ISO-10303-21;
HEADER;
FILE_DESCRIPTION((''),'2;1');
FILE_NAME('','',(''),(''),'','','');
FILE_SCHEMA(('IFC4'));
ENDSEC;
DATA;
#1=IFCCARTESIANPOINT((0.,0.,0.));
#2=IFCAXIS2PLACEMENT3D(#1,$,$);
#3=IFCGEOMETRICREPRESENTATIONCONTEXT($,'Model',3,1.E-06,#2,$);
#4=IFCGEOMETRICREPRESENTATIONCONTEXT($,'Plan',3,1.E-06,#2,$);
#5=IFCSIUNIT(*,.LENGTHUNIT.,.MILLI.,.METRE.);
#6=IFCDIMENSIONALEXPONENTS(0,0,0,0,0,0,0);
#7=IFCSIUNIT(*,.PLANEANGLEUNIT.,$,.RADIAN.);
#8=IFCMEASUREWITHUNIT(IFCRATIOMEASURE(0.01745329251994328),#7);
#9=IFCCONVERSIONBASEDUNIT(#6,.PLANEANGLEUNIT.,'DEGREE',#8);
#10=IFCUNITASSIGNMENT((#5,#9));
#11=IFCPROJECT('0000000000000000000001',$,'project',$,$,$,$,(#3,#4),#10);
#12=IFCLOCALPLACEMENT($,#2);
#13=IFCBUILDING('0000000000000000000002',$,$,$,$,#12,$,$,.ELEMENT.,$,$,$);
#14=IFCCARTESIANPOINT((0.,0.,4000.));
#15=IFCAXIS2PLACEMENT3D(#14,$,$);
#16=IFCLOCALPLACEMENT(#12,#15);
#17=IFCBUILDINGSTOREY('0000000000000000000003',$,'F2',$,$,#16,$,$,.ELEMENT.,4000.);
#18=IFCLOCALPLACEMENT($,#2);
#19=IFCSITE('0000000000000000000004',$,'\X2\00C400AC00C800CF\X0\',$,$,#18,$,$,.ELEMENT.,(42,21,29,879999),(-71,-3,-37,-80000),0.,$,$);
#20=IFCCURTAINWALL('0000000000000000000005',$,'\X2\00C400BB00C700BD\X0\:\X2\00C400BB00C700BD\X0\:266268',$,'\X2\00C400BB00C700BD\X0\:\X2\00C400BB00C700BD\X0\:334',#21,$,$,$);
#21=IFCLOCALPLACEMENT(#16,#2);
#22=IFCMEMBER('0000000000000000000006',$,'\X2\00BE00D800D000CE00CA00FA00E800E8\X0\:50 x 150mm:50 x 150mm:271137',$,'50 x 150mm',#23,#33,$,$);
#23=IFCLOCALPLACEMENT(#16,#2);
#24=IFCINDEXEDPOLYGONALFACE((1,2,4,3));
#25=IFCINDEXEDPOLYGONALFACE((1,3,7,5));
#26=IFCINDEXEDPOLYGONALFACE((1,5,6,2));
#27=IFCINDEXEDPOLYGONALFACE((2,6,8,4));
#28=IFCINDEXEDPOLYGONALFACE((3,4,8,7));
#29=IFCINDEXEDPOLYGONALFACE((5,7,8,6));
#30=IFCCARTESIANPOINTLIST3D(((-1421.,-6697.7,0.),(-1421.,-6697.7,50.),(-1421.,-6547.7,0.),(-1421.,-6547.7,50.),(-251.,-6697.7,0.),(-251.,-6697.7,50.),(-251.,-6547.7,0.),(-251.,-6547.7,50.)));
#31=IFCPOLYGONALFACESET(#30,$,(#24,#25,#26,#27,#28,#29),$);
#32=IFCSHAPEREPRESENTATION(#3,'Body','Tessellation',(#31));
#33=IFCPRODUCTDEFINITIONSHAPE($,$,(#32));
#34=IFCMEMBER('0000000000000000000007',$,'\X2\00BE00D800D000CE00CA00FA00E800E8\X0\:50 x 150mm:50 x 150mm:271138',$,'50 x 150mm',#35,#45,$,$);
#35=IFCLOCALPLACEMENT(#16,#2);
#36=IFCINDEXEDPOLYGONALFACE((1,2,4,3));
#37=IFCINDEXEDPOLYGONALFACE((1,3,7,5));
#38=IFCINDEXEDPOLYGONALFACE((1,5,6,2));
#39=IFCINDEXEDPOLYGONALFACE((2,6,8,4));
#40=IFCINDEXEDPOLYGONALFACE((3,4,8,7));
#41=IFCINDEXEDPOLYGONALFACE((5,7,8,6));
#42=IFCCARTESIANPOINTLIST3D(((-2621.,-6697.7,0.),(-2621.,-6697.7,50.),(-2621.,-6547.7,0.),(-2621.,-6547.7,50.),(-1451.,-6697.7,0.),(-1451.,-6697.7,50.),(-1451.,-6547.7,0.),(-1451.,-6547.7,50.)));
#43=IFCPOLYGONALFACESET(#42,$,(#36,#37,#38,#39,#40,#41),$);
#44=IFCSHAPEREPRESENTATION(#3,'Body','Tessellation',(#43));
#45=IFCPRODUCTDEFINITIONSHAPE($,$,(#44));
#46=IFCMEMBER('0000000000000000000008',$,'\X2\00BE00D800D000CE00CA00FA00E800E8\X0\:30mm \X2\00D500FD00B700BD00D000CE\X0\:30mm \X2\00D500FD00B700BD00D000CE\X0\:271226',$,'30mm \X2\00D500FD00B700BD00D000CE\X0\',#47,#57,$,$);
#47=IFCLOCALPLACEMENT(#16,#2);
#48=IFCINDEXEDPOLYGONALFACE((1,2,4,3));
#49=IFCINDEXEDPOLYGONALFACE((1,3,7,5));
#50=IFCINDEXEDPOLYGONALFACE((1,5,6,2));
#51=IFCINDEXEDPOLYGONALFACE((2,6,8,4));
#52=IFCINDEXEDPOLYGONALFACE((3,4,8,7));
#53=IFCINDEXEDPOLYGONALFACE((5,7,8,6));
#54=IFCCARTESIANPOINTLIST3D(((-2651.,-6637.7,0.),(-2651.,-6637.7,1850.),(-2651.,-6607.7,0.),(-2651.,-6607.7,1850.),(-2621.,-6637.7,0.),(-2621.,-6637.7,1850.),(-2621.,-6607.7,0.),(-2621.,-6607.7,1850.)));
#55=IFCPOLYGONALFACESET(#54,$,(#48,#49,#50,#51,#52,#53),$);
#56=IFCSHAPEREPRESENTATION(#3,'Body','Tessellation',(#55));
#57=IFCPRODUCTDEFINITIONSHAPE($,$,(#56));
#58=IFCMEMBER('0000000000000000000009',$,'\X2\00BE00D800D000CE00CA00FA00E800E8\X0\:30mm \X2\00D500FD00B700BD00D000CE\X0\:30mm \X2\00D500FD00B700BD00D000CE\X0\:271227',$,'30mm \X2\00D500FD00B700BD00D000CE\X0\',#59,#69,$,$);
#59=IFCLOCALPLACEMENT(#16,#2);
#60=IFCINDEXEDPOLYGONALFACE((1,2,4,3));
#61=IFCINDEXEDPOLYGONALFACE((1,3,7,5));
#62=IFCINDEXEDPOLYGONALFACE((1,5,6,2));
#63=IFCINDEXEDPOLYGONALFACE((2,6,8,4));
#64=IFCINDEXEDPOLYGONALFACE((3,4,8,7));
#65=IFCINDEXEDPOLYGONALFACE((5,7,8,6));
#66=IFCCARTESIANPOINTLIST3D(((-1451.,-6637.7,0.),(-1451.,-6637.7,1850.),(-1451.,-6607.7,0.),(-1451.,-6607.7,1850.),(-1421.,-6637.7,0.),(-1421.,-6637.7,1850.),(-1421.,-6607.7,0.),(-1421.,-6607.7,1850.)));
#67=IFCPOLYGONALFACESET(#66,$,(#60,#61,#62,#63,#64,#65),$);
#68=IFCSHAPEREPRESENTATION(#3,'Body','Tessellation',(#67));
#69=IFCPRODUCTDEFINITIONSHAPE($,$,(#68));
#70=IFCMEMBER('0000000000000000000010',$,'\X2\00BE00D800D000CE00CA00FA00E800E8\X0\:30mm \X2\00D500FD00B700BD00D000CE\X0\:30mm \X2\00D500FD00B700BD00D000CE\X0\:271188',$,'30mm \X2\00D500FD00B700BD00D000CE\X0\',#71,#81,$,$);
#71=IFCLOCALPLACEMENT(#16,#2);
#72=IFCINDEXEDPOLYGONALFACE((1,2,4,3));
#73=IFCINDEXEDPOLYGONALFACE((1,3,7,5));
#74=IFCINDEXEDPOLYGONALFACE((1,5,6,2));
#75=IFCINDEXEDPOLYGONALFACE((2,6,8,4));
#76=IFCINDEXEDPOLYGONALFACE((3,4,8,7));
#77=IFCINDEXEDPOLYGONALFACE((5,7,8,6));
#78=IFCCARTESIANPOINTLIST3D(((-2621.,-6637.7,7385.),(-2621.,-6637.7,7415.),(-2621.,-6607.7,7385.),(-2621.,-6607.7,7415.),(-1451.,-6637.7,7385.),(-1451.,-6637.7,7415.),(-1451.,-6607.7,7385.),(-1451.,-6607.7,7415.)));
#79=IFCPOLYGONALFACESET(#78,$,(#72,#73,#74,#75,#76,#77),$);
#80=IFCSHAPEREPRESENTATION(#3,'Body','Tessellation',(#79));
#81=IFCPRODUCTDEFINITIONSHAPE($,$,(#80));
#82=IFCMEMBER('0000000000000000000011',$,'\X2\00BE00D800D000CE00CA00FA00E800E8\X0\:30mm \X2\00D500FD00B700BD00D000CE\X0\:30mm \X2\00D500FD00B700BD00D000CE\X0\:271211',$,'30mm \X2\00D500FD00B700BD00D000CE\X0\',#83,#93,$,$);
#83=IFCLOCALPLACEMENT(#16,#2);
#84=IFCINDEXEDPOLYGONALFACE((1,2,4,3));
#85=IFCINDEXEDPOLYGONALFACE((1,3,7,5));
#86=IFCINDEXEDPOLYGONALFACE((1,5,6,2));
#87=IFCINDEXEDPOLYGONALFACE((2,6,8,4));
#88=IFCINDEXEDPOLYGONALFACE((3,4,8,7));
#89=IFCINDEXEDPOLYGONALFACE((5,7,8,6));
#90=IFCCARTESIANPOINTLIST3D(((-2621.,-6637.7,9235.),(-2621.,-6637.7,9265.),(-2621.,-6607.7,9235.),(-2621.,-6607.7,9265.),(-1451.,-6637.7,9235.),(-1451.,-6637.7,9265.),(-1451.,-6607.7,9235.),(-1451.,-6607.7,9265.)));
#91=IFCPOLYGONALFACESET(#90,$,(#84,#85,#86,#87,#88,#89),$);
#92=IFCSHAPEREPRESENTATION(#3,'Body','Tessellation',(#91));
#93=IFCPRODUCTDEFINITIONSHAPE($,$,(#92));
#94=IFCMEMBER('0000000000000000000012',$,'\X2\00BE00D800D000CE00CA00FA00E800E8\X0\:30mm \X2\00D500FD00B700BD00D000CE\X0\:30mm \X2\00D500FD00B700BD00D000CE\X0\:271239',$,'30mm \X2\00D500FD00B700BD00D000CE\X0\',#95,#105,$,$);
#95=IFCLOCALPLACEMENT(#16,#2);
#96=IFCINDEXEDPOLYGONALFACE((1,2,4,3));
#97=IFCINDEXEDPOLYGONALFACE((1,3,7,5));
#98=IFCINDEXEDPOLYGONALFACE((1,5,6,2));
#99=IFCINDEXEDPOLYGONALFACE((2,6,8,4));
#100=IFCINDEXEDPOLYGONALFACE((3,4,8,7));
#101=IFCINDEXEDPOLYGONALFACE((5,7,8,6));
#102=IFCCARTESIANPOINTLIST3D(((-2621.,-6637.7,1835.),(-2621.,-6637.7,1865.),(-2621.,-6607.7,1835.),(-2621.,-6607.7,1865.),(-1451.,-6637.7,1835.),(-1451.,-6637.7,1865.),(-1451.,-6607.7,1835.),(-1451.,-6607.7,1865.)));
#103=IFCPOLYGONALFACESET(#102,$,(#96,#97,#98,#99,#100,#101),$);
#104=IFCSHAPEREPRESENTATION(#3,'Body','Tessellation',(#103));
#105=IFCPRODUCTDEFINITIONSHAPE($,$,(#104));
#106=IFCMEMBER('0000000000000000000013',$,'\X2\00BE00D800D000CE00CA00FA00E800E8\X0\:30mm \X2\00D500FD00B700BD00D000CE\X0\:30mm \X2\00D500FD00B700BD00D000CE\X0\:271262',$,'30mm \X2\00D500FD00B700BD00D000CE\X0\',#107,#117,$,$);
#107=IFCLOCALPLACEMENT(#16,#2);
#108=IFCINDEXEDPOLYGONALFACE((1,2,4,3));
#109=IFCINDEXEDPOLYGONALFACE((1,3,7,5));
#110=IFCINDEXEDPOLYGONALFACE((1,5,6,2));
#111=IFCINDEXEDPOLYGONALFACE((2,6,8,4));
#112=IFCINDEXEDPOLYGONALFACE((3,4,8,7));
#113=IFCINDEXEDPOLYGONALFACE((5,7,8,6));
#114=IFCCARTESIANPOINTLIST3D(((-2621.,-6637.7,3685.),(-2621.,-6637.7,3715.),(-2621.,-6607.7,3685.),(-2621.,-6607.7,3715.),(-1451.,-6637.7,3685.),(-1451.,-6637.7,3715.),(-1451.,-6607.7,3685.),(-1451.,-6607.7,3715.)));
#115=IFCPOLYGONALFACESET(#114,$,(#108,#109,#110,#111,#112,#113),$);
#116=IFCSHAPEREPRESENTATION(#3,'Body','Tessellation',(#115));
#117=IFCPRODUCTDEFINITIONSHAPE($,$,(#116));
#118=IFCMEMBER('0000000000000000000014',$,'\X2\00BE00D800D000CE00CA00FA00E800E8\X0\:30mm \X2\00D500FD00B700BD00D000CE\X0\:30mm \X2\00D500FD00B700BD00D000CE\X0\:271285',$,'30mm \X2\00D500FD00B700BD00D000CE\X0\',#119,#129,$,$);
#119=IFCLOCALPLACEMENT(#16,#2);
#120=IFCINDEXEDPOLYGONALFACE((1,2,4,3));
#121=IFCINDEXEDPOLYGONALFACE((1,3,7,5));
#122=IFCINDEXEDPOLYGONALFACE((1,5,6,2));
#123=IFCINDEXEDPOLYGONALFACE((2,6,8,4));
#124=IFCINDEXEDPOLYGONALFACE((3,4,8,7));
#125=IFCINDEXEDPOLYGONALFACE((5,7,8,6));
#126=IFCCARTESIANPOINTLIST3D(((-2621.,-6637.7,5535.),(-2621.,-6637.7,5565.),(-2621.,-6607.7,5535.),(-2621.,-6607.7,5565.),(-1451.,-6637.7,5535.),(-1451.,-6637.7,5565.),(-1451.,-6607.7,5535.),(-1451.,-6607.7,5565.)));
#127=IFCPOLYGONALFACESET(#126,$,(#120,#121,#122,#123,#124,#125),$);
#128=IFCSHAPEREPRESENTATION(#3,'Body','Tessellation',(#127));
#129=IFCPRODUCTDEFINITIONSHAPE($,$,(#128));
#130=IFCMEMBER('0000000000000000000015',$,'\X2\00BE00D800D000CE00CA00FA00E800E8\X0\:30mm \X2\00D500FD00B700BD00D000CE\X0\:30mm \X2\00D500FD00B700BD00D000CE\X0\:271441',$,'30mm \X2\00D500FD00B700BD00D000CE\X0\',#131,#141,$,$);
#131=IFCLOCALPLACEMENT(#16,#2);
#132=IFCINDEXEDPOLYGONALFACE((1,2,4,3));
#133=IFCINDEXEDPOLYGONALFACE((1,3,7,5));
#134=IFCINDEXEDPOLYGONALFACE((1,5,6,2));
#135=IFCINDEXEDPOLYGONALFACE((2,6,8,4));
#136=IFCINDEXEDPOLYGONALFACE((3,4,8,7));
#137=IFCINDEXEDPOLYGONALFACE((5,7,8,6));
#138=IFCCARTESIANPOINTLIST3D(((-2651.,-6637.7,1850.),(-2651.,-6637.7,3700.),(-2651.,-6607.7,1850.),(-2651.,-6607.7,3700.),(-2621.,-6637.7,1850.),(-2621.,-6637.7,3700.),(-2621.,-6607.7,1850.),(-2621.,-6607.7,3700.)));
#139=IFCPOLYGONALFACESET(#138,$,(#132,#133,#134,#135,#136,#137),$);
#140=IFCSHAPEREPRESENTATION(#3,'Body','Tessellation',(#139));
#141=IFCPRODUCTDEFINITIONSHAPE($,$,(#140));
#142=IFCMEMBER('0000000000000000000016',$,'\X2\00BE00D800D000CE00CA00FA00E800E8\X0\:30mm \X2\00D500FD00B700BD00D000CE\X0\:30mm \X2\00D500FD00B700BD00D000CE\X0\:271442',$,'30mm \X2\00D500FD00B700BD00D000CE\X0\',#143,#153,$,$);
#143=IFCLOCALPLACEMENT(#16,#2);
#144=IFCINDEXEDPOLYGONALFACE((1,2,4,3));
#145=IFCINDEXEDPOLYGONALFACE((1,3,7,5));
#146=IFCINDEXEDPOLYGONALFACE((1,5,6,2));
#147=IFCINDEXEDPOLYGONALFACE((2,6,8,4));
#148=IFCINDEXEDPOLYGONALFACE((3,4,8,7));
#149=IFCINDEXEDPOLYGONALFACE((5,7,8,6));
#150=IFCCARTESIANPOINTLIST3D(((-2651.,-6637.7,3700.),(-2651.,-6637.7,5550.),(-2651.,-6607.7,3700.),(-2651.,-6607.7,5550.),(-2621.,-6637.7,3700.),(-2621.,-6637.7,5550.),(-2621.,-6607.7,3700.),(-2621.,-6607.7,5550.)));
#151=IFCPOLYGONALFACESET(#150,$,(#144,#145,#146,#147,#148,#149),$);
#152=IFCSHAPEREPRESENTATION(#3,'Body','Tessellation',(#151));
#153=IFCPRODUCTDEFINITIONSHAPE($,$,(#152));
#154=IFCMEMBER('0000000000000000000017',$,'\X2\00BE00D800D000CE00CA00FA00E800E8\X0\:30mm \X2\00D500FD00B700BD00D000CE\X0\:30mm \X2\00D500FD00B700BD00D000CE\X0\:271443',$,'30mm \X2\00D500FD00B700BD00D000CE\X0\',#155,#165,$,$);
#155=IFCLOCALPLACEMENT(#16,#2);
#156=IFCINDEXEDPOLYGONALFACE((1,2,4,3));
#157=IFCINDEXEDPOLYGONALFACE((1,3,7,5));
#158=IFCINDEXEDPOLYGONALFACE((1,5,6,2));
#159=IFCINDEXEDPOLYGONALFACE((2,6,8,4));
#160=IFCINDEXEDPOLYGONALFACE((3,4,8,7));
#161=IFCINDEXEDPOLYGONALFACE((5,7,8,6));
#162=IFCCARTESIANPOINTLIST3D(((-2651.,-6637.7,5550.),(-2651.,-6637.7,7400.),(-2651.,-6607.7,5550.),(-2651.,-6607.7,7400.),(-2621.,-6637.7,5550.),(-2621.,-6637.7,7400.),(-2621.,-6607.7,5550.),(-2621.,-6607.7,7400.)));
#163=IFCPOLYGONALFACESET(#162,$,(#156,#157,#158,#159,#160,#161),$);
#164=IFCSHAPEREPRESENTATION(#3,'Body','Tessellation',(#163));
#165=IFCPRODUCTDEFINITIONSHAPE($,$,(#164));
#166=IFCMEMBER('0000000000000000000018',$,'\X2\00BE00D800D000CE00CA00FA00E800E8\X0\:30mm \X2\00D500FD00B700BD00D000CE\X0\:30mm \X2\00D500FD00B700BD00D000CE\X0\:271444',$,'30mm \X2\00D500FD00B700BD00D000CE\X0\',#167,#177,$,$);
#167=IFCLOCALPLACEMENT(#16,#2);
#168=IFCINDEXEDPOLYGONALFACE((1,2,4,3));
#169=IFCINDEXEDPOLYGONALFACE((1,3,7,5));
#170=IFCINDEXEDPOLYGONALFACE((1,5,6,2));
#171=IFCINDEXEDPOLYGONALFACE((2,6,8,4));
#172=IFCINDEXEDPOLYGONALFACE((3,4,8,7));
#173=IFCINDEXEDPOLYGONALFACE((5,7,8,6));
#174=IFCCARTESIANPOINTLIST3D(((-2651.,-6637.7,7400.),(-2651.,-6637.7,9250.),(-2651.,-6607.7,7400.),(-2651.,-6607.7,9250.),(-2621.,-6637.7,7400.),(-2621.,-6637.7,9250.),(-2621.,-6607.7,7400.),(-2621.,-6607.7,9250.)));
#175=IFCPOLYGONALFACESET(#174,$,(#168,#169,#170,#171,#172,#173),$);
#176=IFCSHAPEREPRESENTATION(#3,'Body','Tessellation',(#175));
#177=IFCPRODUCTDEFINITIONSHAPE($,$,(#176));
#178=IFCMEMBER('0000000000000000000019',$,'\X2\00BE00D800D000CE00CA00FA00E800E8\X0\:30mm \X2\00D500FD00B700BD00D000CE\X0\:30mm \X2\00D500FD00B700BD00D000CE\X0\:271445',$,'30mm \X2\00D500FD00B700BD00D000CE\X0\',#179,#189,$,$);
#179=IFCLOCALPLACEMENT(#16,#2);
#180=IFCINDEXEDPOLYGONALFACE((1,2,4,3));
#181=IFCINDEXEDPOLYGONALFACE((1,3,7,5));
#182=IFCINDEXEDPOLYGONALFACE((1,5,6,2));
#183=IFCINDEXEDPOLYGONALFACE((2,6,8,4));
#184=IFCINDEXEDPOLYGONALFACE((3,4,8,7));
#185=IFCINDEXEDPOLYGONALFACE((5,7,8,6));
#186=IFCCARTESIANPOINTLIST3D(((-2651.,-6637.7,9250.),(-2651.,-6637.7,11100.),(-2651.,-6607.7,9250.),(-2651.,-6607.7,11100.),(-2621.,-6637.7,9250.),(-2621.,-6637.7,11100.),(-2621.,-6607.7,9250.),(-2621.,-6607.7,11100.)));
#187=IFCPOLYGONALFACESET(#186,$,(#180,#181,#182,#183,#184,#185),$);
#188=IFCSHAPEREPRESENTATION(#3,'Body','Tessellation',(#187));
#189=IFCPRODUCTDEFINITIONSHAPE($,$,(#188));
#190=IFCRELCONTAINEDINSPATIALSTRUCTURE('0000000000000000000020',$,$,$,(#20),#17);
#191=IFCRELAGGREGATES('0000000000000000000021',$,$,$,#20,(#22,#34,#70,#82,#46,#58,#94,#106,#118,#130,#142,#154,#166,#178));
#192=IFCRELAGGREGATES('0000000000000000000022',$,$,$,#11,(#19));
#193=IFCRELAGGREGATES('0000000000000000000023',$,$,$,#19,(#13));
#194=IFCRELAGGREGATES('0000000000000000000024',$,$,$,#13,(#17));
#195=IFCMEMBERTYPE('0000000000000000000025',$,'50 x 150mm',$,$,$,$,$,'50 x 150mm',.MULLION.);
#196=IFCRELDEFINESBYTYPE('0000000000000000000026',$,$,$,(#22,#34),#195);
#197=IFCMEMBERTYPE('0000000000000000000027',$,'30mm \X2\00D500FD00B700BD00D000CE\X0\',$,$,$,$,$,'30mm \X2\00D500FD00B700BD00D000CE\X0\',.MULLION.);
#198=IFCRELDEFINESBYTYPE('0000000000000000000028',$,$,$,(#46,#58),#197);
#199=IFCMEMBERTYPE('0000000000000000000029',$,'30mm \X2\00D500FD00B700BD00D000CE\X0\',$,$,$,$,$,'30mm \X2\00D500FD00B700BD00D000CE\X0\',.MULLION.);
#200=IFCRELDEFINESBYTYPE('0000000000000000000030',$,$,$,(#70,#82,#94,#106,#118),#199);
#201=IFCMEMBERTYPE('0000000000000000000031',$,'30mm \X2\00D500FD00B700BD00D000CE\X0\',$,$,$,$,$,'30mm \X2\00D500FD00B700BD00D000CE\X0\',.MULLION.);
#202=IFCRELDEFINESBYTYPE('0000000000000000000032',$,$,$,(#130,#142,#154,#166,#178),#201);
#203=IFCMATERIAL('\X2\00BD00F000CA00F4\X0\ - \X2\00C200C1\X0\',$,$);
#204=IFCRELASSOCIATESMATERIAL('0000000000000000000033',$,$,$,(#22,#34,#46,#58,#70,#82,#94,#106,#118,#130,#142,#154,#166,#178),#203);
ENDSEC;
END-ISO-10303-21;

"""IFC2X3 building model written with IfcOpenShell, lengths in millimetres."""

from ifc_helpers import new_model, entity, si_unit, converted_unit, frame, origin, origin_2d_with_axis, place, context, project, spatial, rectangle, extrude, source, transform, mapped, material, type_object, type_shapes, element, aggregate, save


model = new_model("IFC2X3")

# Units and contexts
model_context = context("Model", 3, precision=1e-06, world=origin())
plan_context = context("Plan", 3, precision=1e-06, world=origin())
ifc_project = project(units=[si_unit("LENGTHUNIT", "METRE", prefix="MILLI"), converted_unit("PLANEANGLEUNIT", "DEGREE", entity("IfcRatioMeasure", 0.01745329251994328), si_unit("PLANEANGLEUNIT", "RADIAN"), dimensions=[0, 0, 0, 0, 0, 0, 0])], contexts=[model_context, plan_context])

# Site, building, storey
site_placement = place(None, origin())
site = spatial("IfcSite", under=ifc_project, at=site_placement, Name="Ä¬ÈÏ", CompositionType="ELEMENT", RefLatitude=(42, 21, 29, 879999), RefLongitude=(-71, -3, -37, -80000), RefElevation=0.0)
building_placement = place(None, origin())
building = spatial("IfcBuilding", under=site, at=building_placement, CompositionType="ELEMENT")
storey_placement = place(building_placement, frame((0.0, 0.0, 4000.0)))
storey = spatial("IfcBuildingStorey", under=building, at=storey_placement, Name="F2", CompositionType="ELEMENT", Elevation=4000.0)

# Curtain wall, members
curtain_wall_placement = place(storey_placement, origin())
curtain_wall = element("IfcCurtainWall", 1, at=curtain_wall_placement, inside=storey, Name="Ä»Ç½:Ä»Ç½:266268", ObjectType="Ä»Ç½:Ä»Ç½:334")
ifc_material_1 = material(Name="½ðÊô - ÂÁ")
member_type_1 = type_object("IfcMemberType", Name="50 x 150mm", ElementType="50 x 150mm", PredefinedType="MULLION")
shared_shape_1 = source(origin(), model_context, "Body", "SweptSolid", [
    extrude(rectangle(XDim=50.0, YDim=150.0, at=origin_2d_with_axis()), frame((-25.0, 0.0, -1170.0), z_axis=(0.0, 0.0, 1.0), x_axis=(-1.0, 0.0, 0.0)), (0.0, 0.0, 1.0), 1170.0),
])
type_shapes(member_type_1, [shared_shape_1])
member_1_placement = place(storey_placement, frame((-1421.0, -6622.7, 0.0), z_axis=(-1.0, 0.0, 0.0), x_axis=(0.0, 0.0, -1.0)))
member_1 = element("IfcMember", 2, at=member_1_placement, type_object=member_type_1, material=ifc_material_1, Name="¾ØÐÎÊúèè:50 x 150mm:50 x 150mm:271137", ObjectType="50 x 150mm", context=model_context, shape_type="MappedRepresentation", body=[
    mapped(shared_shape_1, transform((0.0, 0.0, 0.0), scale=1.0)),
])
member_2_placement = place(storey_placement, frame((-2621.0, -6622.7, 0.0), z_axis=(-1.0, 0.0, 0.0), x_axis=(0.0, 0.0, -1.0)))
member_2 = element("IfcMember", 3, at=member_2_placement, type_object=member_type_1, material=ifc_material_1, Name="¾ØÐÎÊúèè:50 x 150mm:50 x 150mm:271138", ObjectType="50 x 150mm", context=model_context, shape_type="MappedRepresentation", body=[
    mapped(shared_shape_1, transform((0.0, 0.0, 0.0), scale=1.0)),
])
member_type_2 = type_object("IfcMemberType", Name="30mm Õý·½ÐÎ", ElementType="30mm Õý·½ÐÎ", PredefinedType="MULLION")
shared_shape_2 = source(origin(), model_context, "Body", "SweptSolid", [
    extrude(rectangle(XDim=30.0, YDim=30.0, at=origin_2d_with_axis()), frame((0.0, 0.0, -1850.0), z_axis=(0.0, 0.0, 1.0), x_axis=(-1.0, 0.0, 0.0)), (0.0, 0.0, 1.0), 1850.0),
])
type_shapes(member_type_2, [shared_shape_2])
member_3_placement = place(storey_placement, frame((-2636.0, -6622.7, 0.0), z_axis=(0.0, 0.0, -1.0), x_axis=(1.0, 0.0, 0.0)))
member_3 = element("IfcMember", 4, at=member_3_placement, type_object=member_type_2, material=ifc_material_1, Name="¾ØÐÎÊúèè:30mm Õý·½ÐÎ:30mm Õý·½ÐÎ:271226", ObjectType="30mm Õý·½ÐÎ", context=model_context, shape_type="MappedRepresentation", body=[
    mapped(shared_shape_2, transform((0.0, 0.0, 0.0), scale=1.0)),
])
member_4_placement = place(storey_placement, frame((-1436.0, -6622.7, 0.0), z_axis=(0.0, 0.0, -1.0), x_axis=(1.0, 0.0, 0.0)))
member_4 = element("IfcMember", 5, at=member_4_placement, type_object=member_type_2, material=ifc_material_1, Name="¾ØÐÎÊúèè:30mm Õý·½ÐÎ:30mm Õý·½ÐÎ:271227", ObjectType="30mm Õý·½ÐÎ", context=model_context, shape_type="MappedRepresentation", body=[
    mapped(shared_shape_2, transform((0.0, 0.0, 0.0), scale=1.0)),
])
member_type_3 = type_object("IfcMemberType", Name="30mm Õý·½ÐÎ", ElementType="30mm Õý·½ÐÎ", PredefinedType="MULLION")
shared_shape_3 = source(origin(), model_context, "Body", "SweptSolid", [
    extrude(rectangle(XDim=30.0, YDim=30.0, at=origin_2d_with_axis()), frame((0.0, 0.0, -1170.0), z_axis=(0.0, 0.0, 1.0), x_axis=(-1.0, 0.0, 0.0)), (0.0, 0.0, 1.0), 1170.0),
])
type_shapes(member_type_3, [shared_shape_3])
placement_1 = place(building_placement, frame((0.0, 0.0, 11400.0)))
member_5_placement = place(placement_1, frame((-1451.0, -6622.7, 0.0), z_axis=(1.0, 0.0, 0.0), x_axis=(0.0, 0.0, 1.0)))
member_5 = element("IfcMember", 6, at=member_5_placement, type_object=member_type_3, material=ifc_material_1, Name="¾ØÐÎÊúèè:30mm Õý·½ÐÎ:30mm Õý·½ÐÎ:271188", ObjectType="30mm Õý·½ÐÎ", context=model_context, shape_type="MappedRepresentation", body=[
    mapped(shared_shape_3, transform((0.0, 0.0, 0.0), scale=1.0)),
])
member_6_placement = place(placement_1, frame((-1451.0, -6622.7, 1850.0), z_axis=(1.0, 0.0, 0.0), x_axis=(0.0, 0.0, 1.0)))
member_6 = element("IfcMember", 7, at=member_6_placement, type_object=member_type_3, material=ifc_material_1, Name="¾ØÐÎÊúèè:30mm Õý·½ÐÎ:30mm Õý·½ÐÎ:271211", ObjectType="30mm Õý·½ÐÎ", context=model_context, shape_type="MappedRepresentation", body=[
    mapped(shared_shape_3, transform((0.0, 0.0, 0.0), scale=1.0)),
])
member_7_placement = place(storey_placement, frame((-1451.0, -6622.7, 1850.0), z_axis=(1.0, 0.0, 0.0), x_axis=(0.0, 0.0, 1.0)))
member_7 = element("IfcMember", 8, at=member_7_placement, type_object=member_type_3, material=ifc_material_1, Name="¾ØÐÎÊúèè:30mm Õý·½ÐÎ:30mm Õý·½ÐÎ:271239", ObjectType="30mm Õý·½ÐÎ", context=model_context, shape_type="MappedRepresentation", body=[
    mapped(shared_shape_3, transform((0.0, 0.0, 0.0), scale=1.0)),
])
placement_2 = place(building_placement, frame((0.0, 0.0, 7700.0)))
member_8_placement = place(placement_2, frame((-1451.0, -6622.7, 0.0), z_axis=(1.0, 0.0, 0.0), x_axis=(0.0, 0.0, 1.0)))
member_8 = element("IfcMember", 9, at=member_8_placement, type_object=member_type_3, material=ifc_material_1, Name="¾ØÐÎÊúèè:30mm Õý·½ÐÎ:30mm Õý·½ÐÎ:271262", ObjectType="30mm Õý·½ÐÎ", context=model_context, shape_type="MappedRepresentation", body=[
    mapped(shared_shape_3, transform((0.0, 0.0, 0.0), scale=1.0)),
])
member_9_placement = place(placement_2, frame((-1451.0, -6622.7, 1850.0), z_axis=(1.0, 0.0, 0.0), x_axis=(0.0, 0.0, 1.0)))
member_9 = element("IfcMember", 10, at=member_9_placement, type_object=member_type_3, material=ifc_material_1, Name="¾ØÐÎÊúèè:30mm Õý·½ÐÎ:30mm Õý·½ÐÎ:271285", ObjectType="30mm Õý·½ÐÎ", context=model_context, shape_type="MappedRepresentation", body=[
    mapped(shared_shape_3, transform((0.0, 0.0, 0.0), scale=1.0)),
])
member_type_4 = type_object("IfcMemberType", Name="30mm Õý·½ÐÎ", ElementType="30mm Õý·½ÐÎ", PredefinedType="MULLION")
shared_shape_4 = source(origin(), model_context, "Body", "SweptSolid", [
    extrude(rectangle(XDim=30.0, YDim=30.0, at=origin_2d_with_axis()), frame((0.0, 0.0, -1850.0), z_axis=(0.0, 0.0, 1.0), x_axis=(-1.0, 0.0, 0.0)), (0.0, 0.0, 1.0), 1850.0),
])
type_shapes(member_type_4, [shared_shape_4])
member_10_placement = place(storey_placement, frame((-2636.0, -6622.7, 1850.0), z_axis=(0.0, 0.0, -1.0), x_axis=(1.0, 0.0, 0.0)))
member_10 = element("IfcMember", 11, at=member_10_placement, type_object=member_type_4, material=ifc_material_1, Name="¾ØÐÎÊúèè:30mm Õý·½ÐÎ:30mm Õý·½ÐÎ:271441", ObjectType="30mm Õý·½ÐÎ", context=model_context, shape_type="MappedRepresentation", body=[
    mapped(shared_shape_4, transform((0.0, 0.0, 0.0), scale=1.0)),
])
member_11_placement = place(placement_2, frame((-2636.0, -6622.7, 0.0), z_axis=(0.0, 0.0, -1.0), x_axis=(1.0, 0.0, 0.0)))
member_11 = element("IfcMember", 12, at=member_11_placement, type_object=member_type_4, material=ifc_material_1, Name="¾ØÐÎÊúèè:30mm Õý·½ÐÎ:30mm Õý·½ÐÎ:271442", ObjectType="30mm Õý·½ÐÎ", context=model_context, shape_type="MappedRepresentation", body=[
    mapped(shared_shape_4, transform((0.0, 0.0, 0.0), scale=1.0)),
])
member_12_placement = place(placement_2, frame((-2636.0, -6622.7, 1850.0), z_axis=(0.0, 0.0, -1.0), x_axis=(1.0, 0.0, 0.0)))
member_12 = element("IfcMember", 13, at=member_12_placement, type_object=member_type_4, material=ifc_material_1, Name="¾ØÐÎÊúèè:30mm Õý·½ÐÎ:30mm Õý·½ÐÎ:271443", ObjectType="30mm Õý·½ÐÎ", context=model_context, shape_type="MappedRepresentation", body=[
    mapped(shared_shape_4, transform((0.0, 0.0, 0.0), scale=1.0)),
])
member_13_placement = place(placement_1, frame((-2636.0, -6622.7, 0.0), z_axis=(0.0, 0.0, -1.0), x_axis=(1.0, 0.0, 0.0)))
member_13 = element("IfcMember", 14, at=member_13_placement, type_object=member_type_4, material=ifc_material_1, Name="¾ØÐÎÊúèè:30mm Õý·½ÐÎ:30mm Õý·½ÐÎ:271444", ObjectType="30mm Õý·½ÐÎ", context=model_context, shape_type="MappedRepresentation", body=[
    mapped(shared_shape_4, transform((0.0, 0.0, 0.0), scale=1.0)),
])
member_14_placement = place(placement_1, frame((-2636.0, -6622.7, 1850.0), z_axis=(0.0, 0.0, -1.0), x_axis=(1.0, 0.0, 0.0)))
member_14 = element("IfcMember", 15, at=member_14_placement, type_object=member_type_4, material=ifc_material_1, Name="¾ØÐÎÊúèè:30mm Õý·½ÐÎ:30mm Õý·½ÐÎ:271445", ObjectType="30mm Õý·½ÐÎ", context=model_context, shape_type="MappedRepresentation", body=[
    mapped(shared_shape_4, transform((0.0, 0.0, 0.0), scale=1.0)),
])

aggregate(curtain_wall, [member_1, member_2, member_5, member_6, member_3, member_4, member_7, member_8, member_9, member_10, member_11, member_12, member_13, member_14])

save(model, "model.ifc")
